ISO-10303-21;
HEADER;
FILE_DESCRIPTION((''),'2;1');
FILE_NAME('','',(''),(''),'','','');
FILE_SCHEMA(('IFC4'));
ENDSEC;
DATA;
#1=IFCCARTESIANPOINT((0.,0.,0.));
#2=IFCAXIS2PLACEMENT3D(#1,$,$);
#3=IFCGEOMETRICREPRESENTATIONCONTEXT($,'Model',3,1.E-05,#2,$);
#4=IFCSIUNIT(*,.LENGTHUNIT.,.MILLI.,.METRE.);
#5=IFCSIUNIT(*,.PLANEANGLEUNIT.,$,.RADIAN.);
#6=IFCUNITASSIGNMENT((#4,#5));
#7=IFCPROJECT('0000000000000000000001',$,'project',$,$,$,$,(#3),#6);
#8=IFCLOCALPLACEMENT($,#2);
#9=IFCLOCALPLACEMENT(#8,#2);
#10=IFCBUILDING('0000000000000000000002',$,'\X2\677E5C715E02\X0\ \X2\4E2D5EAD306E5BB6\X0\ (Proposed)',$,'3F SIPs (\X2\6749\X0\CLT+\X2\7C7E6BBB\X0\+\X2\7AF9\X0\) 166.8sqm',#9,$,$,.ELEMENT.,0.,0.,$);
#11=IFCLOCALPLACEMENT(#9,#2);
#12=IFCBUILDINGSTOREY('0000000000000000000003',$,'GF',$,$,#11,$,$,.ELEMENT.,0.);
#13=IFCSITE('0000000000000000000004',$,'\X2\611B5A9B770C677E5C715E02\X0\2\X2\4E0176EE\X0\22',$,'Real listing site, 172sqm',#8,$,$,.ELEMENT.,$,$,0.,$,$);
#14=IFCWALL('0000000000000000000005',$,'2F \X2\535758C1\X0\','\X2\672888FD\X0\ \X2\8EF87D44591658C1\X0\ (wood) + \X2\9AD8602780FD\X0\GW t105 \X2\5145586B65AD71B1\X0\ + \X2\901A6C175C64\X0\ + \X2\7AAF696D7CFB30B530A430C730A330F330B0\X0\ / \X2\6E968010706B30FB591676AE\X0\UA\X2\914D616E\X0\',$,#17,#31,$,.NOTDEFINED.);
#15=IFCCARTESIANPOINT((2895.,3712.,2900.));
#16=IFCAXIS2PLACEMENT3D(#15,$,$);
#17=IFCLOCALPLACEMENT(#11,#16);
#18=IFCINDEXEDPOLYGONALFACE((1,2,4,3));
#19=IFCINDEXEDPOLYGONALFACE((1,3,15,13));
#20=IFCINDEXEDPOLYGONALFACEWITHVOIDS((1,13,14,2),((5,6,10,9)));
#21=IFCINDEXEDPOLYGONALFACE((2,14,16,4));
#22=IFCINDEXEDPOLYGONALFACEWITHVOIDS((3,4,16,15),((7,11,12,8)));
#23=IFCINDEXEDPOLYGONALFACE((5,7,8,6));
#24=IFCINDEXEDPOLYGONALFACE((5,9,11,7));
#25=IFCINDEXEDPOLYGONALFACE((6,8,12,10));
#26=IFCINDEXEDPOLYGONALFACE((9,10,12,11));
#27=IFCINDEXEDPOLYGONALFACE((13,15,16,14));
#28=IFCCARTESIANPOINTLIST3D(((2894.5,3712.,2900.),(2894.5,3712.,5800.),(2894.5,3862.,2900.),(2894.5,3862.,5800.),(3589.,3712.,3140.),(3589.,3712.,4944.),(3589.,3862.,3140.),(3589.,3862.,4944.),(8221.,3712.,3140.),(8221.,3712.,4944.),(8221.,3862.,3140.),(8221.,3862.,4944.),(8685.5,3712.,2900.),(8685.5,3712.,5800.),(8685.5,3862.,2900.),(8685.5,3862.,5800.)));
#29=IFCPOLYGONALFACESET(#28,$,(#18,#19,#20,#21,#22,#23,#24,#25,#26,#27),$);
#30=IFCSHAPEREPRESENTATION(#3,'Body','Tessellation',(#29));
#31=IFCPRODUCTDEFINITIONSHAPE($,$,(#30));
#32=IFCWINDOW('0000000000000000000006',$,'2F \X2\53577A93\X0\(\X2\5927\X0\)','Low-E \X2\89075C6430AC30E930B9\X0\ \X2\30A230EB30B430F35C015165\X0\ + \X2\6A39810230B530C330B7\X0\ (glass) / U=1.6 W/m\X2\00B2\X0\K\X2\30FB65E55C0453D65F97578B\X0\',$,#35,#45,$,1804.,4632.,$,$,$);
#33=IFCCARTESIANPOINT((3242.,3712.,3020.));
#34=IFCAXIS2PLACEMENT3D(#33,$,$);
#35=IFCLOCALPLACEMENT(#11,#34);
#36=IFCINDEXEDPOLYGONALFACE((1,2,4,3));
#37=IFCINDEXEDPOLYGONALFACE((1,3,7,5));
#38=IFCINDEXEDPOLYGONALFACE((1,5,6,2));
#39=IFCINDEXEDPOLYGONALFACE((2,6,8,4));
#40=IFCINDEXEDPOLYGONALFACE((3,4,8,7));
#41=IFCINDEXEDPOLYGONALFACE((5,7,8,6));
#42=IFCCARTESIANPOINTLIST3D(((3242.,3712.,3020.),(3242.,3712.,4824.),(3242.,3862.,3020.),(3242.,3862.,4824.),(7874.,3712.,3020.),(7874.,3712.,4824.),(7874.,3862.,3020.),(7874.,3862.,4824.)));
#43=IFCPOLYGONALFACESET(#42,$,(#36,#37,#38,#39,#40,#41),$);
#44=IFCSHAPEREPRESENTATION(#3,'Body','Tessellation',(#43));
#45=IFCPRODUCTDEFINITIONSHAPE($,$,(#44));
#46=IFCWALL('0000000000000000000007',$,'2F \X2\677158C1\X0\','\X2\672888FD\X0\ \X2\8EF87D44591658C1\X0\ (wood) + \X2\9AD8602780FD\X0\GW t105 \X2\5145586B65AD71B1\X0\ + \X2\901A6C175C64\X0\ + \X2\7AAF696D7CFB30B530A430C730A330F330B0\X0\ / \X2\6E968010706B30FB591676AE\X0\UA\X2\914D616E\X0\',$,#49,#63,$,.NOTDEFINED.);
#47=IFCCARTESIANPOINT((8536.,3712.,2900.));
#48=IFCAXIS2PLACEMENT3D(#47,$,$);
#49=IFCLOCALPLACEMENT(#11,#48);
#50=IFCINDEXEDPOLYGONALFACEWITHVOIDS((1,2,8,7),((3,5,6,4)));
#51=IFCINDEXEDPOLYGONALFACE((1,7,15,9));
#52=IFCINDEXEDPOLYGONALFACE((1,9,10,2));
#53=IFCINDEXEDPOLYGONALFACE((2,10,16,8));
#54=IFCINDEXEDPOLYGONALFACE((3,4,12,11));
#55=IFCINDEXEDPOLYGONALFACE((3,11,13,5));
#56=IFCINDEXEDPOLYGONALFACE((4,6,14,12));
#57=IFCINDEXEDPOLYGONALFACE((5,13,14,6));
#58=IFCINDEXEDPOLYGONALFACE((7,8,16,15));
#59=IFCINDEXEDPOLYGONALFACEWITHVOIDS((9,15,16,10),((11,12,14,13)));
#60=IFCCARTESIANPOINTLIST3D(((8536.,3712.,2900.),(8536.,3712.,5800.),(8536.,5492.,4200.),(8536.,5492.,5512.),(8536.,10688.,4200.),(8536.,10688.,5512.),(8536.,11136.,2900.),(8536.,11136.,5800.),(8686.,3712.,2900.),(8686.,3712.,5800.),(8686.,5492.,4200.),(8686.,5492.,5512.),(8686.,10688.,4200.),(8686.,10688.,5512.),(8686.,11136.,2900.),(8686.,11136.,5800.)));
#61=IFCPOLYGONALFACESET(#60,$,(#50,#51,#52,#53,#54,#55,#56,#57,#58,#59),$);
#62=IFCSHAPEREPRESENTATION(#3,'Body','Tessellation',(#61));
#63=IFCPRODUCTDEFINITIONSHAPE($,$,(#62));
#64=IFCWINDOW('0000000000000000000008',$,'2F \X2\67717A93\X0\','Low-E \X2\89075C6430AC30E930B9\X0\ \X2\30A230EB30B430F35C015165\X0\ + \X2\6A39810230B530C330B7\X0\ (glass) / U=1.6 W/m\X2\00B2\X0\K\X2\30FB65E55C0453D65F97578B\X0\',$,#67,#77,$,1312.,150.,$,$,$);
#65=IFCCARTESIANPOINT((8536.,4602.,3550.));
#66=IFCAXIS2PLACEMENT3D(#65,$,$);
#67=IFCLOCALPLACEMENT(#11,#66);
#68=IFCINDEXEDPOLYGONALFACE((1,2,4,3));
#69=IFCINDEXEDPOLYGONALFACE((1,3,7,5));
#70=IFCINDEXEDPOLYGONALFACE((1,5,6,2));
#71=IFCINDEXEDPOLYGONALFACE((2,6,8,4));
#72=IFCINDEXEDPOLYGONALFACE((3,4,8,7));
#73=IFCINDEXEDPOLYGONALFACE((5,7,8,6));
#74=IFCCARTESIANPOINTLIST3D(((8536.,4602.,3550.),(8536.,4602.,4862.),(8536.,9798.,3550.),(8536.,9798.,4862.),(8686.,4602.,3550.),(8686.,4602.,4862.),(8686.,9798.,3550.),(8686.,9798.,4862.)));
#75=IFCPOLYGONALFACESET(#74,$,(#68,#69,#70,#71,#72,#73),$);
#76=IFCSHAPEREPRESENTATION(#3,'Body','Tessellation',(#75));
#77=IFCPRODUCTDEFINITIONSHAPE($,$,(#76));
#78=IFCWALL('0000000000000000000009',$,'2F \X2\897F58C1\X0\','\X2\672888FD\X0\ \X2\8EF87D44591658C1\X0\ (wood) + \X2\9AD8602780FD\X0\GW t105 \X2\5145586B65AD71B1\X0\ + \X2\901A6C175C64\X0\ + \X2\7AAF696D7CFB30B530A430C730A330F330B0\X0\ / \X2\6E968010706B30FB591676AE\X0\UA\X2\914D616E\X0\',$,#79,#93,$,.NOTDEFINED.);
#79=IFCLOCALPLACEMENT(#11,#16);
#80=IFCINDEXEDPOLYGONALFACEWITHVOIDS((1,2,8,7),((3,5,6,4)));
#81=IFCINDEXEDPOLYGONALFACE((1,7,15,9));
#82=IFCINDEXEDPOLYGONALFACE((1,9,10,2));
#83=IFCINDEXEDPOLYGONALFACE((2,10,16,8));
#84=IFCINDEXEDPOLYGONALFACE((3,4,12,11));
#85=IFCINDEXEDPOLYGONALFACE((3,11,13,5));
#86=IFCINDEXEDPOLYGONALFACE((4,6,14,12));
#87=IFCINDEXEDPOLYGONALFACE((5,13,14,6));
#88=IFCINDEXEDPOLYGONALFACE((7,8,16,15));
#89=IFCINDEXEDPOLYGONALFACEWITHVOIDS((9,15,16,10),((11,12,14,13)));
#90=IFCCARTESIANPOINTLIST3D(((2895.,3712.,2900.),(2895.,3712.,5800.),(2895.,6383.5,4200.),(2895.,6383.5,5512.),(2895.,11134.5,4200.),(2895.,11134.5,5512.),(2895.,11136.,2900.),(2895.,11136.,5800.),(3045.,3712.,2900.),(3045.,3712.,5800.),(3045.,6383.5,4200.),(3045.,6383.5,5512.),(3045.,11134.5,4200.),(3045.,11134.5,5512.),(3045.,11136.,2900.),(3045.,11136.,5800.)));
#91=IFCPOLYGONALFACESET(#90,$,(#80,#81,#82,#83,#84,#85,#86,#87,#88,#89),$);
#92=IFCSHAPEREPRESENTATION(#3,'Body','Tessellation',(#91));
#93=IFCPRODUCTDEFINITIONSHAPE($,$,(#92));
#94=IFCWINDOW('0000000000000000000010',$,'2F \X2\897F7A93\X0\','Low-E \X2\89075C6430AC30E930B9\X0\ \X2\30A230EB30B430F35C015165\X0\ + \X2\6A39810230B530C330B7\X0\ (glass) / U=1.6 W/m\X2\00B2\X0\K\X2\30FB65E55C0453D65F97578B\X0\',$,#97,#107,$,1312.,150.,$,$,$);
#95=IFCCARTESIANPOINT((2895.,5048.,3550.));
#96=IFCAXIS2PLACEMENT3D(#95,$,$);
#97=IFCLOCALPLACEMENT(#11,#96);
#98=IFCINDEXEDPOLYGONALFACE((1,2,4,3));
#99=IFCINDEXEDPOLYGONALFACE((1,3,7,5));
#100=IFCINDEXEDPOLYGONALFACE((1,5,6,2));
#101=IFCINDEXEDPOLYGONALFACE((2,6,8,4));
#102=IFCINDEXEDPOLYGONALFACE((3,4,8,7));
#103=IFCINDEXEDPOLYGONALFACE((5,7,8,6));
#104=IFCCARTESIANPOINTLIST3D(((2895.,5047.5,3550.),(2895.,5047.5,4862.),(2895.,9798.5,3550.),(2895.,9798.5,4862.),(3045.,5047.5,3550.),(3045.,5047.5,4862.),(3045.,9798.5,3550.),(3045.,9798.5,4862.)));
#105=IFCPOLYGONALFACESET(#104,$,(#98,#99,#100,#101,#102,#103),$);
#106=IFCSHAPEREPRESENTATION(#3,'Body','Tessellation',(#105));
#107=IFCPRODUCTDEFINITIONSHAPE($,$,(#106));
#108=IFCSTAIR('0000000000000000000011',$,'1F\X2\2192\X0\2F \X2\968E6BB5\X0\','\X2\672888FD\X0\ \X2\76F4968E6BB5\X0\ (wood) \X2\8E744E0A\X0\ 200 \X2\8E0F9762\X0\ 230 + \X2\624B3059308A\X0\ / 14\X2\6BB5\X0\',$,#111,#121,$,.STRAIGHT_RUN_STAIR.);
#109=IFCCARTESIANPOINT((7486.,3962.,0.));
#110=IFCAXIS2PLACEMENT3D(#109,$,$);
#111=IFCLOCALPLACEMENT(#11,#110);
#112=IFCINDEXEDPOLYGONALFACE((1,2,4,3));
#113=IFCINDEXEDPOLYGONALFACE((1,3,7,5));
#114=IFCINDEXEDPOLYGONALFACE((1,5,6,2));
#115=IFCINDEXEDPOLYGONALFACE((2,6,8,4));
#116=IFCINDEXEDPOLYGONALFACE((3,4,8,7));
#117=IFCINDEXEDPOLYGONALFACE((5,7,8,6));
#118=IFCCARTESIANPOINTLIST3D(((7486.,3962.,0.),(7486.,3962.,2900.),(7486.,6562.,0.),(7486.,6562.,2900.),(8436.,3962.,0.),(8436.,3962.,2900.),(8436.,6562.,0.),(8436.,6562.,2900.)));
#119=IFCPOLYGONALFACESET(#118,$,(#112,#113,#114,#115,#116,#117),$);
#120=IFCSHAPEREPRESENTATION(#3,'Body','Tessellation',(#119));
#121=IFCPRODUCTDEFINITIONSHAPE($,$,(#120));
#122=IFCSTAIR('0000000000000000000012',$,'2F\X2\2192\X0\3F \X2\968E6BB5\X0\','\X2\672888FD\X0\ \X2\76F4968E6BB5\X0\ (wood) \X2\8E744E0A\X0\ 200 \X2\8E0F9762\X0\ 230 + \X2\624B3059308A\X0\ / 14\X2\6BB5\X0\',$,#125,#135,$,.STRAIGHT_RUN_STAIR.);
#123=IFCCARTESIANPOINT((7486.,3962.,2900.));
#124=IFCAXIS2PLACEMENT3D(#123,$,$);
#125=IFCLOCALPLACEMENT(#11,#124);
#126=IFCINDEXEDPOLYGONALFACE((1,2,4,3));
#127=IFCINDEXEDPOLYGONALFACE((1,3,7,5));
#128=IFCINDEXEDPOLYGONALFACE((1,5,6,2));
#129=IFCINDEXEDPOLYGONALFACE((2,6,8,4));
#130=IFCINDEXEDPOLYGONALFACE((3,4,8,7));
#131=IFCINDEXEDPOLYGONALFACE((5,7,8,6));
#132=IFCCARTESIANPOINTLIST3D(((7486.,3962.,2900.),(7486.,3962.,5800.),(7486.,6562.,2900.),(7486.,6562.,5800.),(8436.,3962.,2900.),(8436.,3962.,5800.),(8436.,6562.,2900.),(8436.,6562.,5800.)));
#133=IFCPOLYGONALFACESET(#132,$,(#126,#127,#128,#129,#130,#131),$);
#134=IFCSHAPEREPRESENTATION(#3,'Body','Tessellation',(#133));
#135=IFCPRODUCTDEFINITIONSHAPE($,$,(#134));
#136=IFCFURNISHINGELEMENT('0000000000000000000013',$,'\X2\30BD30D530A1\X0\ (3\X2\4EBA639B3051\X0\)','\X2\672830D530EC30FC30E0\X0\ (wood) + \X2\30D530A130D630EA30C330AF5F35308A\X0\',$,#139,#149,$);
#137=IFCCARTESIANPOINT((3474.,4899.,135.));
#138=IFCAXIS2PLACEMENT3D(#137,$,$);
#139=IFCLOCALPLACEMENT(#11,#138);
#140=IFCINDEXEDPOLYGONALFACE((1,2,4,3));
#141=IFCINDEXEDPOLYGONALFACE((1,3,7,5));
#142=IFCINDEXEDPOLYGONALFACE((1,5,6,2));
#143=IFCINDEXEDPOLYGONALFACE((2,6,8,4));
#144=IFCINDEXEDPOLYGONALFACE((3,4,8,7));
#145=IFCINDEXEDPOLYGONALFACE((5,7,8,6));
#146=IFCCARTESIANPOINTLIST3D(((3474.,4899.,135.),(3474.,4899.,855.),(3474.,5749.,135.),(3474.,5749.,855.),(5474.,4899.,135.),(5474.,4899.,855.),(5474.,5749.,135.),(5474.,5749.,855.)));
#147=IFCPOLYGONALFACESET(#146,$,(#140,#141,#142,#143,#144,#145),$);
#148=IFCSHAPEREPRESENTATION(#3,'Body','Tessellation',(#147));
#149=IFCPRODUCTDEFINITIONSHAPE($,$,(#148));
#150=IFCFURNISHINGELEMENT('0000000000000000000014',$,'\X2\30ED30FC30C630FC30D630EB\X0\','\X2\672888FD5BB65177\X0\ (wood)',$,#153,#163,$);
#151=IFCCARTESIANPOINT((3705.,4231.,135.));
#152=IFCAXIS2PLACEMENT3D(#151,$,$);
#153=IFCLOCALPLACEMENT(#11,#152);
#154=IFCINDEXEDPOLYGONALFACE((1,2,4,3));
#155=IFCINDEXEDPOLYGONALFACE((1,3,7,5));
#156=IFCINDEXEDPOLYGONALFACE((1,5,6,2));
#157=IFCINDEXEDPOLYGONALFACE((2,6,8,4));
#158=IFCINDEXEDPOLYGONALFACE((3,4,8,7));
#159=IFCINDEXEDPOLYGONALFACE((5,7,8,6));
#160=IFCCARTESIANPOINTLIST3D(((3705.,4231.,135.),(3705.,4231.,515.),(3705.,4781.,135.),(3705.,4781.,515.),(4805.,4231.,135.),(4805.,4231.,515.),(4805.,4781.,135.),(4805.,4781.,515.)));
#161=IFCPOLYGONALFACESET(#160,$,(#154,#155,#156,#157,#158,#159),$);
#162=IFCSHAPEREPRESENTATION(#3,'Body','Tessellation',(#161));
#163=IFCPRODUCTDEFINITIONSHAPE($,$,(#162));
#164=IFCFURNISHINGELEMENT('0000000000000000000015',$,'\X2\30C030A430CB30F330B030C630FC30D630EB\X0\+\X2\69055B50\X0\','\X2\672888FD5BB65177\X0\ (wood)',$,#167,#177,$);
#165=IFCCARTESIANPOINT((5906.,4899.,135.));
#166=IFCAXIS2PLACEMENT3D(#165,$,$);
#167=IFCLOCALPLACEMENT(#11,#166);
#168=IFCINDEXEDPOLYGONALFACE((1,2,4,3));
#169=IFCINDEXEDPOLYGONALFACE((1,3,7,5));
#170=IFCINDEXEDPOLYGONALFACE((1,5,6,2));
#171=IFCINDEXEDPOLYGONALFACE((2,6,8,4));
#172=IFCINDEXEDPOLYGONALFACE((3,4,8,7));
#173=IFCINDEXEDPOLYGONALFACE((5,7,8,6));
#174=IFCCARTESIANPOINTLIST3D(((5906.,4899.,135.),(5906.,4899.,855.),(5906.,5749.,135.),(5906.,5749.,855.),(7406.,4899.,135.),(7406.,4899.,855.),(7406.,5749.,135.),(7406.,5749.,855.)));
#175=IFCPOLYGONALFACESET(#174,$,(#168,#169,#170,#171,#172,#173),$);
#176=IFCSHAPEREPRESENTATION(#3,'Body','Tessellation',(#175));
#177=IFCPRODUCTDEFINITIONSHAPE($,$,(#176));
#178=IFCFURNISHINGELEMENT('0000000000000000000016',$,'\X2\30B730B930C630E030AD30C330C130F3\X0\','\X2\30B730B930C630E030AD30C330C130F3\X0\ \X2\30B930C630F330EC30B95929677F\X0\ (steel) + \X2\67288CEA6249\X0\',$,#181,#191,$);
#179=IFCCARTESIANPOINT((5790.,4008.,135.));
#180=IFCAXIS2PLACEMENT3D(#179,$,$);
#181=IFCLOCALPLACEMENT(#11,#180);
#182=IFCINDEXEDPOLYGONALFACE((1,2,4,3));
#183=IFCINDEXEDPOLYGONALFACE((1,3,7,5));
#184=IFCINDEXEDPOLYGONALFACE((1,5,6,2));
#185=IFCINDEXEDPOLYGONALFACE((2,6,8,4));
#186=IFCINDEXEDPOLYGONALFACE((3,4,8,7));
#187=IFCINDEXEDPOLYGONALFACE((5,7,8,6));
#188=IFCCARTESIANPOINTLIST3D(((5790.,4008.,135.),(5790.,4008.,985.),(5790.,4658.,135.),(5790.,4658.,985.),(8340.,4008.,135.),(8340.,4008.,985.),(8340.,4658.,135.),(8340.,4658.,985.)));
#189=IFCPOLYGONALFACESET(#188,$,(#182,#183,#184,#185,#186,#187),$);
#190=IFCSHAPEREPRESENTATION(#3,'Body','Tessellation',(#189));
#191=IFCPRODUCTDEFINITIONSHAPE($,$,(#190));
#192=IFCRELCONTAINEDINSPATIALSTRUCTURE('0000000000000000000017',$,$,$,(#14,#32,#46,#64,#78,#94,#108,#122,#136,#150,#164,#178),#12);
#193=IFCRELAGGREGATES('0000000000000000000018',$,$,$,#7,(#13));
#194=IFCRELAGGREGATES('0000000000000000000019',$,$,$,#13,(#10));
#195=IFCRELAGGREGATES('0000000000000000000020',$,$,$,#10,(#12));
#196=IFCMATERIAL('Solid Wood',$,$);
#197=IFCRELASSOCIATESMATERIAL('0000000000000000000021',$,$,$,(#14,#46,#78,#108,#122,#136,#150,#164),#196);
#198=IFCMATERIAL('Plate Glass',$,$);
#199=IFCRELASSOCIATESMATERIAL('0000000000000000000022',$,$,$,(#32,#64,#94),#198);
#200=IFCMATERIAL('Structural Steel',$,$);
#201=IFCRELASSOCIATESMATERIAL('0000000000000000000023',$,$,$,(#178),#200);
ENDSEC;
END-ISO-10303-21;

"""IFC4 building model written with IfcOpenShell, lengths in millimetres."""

from ifc_helpers import new_model, si_unit, frame, frame_2d, origin, place, context, project, spatial, rectangle, extrude, material, element, fill, save


model = new_model("IFC4")

# Units and contexts
model_context = context("Model", 3, precision=1e-05, world=origin())
ifc_project = project(units=[si_unit("LENGTHUNIT", "METRE", prefix="MILLI"), si_unit("PLANEANGLEUNIT", "RADIAN")], contexts=[model_context])

# Site, building, storey
site_placement = place(None, origin())
site = spatial("IfcSite", under=ifc_project, at=site_placement, Name="愛媛県松山市2丁目22", ObjectType="Real listing site, 172sqm", CompositionType="ELEMENT", RefElevation=0.0)
building_placement = place(site_placement, origin())
building = spatial("IfcBuilding", under=site, at=building_placement, Name="松山市 中庭の家 (Proposed)", ObjectType="3F SIPs (杉CLT+籾殻+竹) 166.8sqm", CompositionType="ELEMENT", ElevationOfRefHeight=0.0, ElevationOfTerrain=0.0)
storey_placement = place(building_placement, origin())
storey = spatial("IfcBuildingStorey", under=building, at=storey_placement, Name="GF", CompositionType="ELEMENT", Elevation=0.0)

# Shared definitions
ifc_material_1 = material(Name="Solid Wood")

# Shared definitions
ifc_material_2 = material(Name="Plate Glass")

# Walls, openings, windows
wall_1_placement = place(storey_placement, frame((2895.0, 3712.0, 2900.0)))
wall_1 = element("IfcWall", 1, at=wall_1_placement, inside=storey, material=ifc_material_1, Name="2F 南壁", Description="木製 軸組外壁 (wood) + 高性能GW t105 充填断熱 + 通気層 + 窯業系サイディング / 準耐火・外皮UA配慮", PredefinedType="NOTDEFINED", context=model_context, shape_type="SweptSolid", body=[
    extrude(rectangle(XDim=5791.0, YDim=150.0, at=frame_2d((2895.0, 75.0))), frame((2895.0, 3712.0, 2900.0)), (0.0, 0.0, 1.0), 2900.0),
])
opening_1_placement = place(storey_placement, frame((3242.0, 3712.0, 3020.0)))
opening_1 = element("IfcOpeningElement", 2, at=opening_1_placement, cuts=wall_1, PredefinedType="NOTDEFINED", context=model_context, shape_type="SweptSolid", body=[
    extrude(rectangle(XDim=4632.0, YDim=150.0, at=frame_2d((2316.0, 75.0))), frame((3242.0, 3712.0, 3020.0)), (0.0, 0.0, 1.0), 1804.0),
])
window_1_placement = place(storey_placement, frame((3242.0, 3712.0, 3020.0)))
window_1 = element("IfcWindow", 3, at=window_1_placement, inside=storey, material=ifc_material_2, Name="2F 南窓(大)", Description="Low-E 複層ガラス アルゴン封入 + 樹脂サッシ (glass) / U=1.6 W/m²K・日射取得型", OverallHeight=1804.0, OverallWidth=4632.0, context=model_context, shape_type="SweptSolid", body=[
    extrude(rectangle(XDim=4632.0, YDim=150.0, at=frame_2d((2316.0, 75.0))), frame((3242.0, 3712.0, 3020.0)), (0.0, 0.0, 1.0), 1804.0),
])
fill(opening_1, window_1)
wall_2_placement = place(storey_placement, frame((8536.0, 3712.0, 2900.0)))
wall_2 = element("IfcWall", 4, at=wall_2_placement, inside=storey, material=ifc_material_1, Name="2F 東壁", Description="木製 軸組外壁 (wood) + 高性能GW t105 充填断熱 + 通気層 + 窯業系サイディング / 準耐火・外皮UA配慮", PredefinedType="NOTDEFINED", context=model_context, shape_type="SweptSolid", body=[
    extrude(rectangle(XDim=150.0, YDim=7424.0, at=frame_2d((75.0, 3712.0))), frame((8536.0, 3712.0, 2900.0)), (0.0, 0.0, 1.0), 2900.0),
])
opening_2_placement = place(storey_placement, frame((8536.0, 4602.0, 3550.0)))
opening_2 = element("IfcOpeningElement", 5, at=opening_2_placement, cuts=wall_2, PredefinedType="NOTDEFINED", context=model_context, shape_type="SweptSolid", body=[
    extrude(rectangle(XDim=150.0, YDim=5196.0, at=frame_2d((75.0, 2598.0))), frame((8536.0, 4602.0, 3550.0)), (0.0, 0.0, 1.0), 1312.0),
])
window_2_placement = place(storey_placement, frame((8536.0, 4602.0, 3550.0)))
window_2 = element("IfcWindow", 6, at=window_2_placement, inside=storey, material=ifc_material_2, Name="2F 東窓", Description="Low-E 複層ガラス アルゴン封入 + 樹脂サッシ (glass) / U=1.6 W/m²K・日射取得型", OverallHeight=1312.0, OverallWidth=150.0, context=model_context, shape_type="SweptSolid", body=[
    extrude(rectangle(XDim=150.0, YDim=5196.0, at=frame_2d((75.0, 2598.0))), frame((8536.0, 4602.0, 3550.0)), (0.0, 0.0, 1.0), 1312.0),
])
fill(opening_2, window_2)
wall_3_placement = place(storey_placement, frame((2895.0, 3712.0, 2900.0)))
wall_3 = element("IfcWall", 7, at=wall_3_placement, inside=storey, material=ifc_material_1, Name="2F 西壁", Description="木製 軸組外壁 (wood) + 高性能GW t105 充填断熱 + 通気層 + 窯業系サイディング / 準耐火・外皮UA配慮", PredefinedType="NOTDEFINED", context=model_context, shape_type="SweptSolid", body=[
    extrude(rectangle(XDim=150.0, YDim=7424.0, at=frame_2d((75.0, 3712.0))), frame((2895.0, 3712.0, 2900.0)), (0.0, 0.0, 1.0), 2900.0),
])
opening_3_placement = place(storey_placement, frame((2895.0, 5048.0, 3550.0)))
opening_3 = element("IfcOpeningElement", 8, at=opening_3_placement, cuts=wall_3, PredefinedType="NOTDEFINED", context=model_context, shape_type="SweptSolid", body=[
    extrude(rectangle(XDim=150.0, YDim=4751.0, at=frame_2d((75.0, 2375.0))), frame((2895.0, 5048.0, 3550.0)), (0.0, 0.0, 1.0), 1312.0),
])
window_3_placement = place(storey_placement, frame((2895.0, 5048.0, 3550.0)))
window_3 = element("IfcWindow", 9, at=window_3_placement, inside=storey, material=ifc_material_2, Name="2F 西窓", Description="Low-E 複層ガラス アルゴン封入 + 樹脂サッシ (glass) / U=1.6 W/m²K・日射取得型", OverallHeight=1312.0, OverallWidth=150.0, context=model_context, shape_type="SweptSolid", body=[
    extrude(rectangle(XDim=150.0, YDim=4751.0, at=frame_2d((75.0, 2375.0))), frame((2895.0, 5048.0, 3550.0)), (0.0, 0.0, 1.0), 1312.0),
])
fill(opening_3, window_3)

# Stairs
stair_1_placement = place(storey_placement, frame((7486.0, 3962.0, 0.0)))
element("IfcStair", 10, at=stair_1_placement, inside=storey, material=ifc_material_1, Name="1F→2F 階段", Description="木製 直階段 (wood) 蹴上 200 踏面 230 + 手すり / 14段", PredefinedType="STRAIGHT_RUN_STAIR", context=model_context, shape_type="SweptSolid", body=[
    extrude(rectangle(XDim=950.0, YDim=2600.0, at=frame_2d((475.0, 1300.0))), frame((7486.0, 3962.0, 0.0)), (0.0, 0.0, 1.0), 2900.0),
])
stair_2_placement = place(storey_placement, frame((7486.0, 3962.0, 2900.0)))
element("IfcStair", 11, at=stair_2_placement, inside=storey, material=ifc_material_1, Name="2F→3F 階段", Description="木製 直階段 (wood) 蹴上 200 踏面 230 + 手すり / 14段", PredefinedType="STRAIGHT_RUN_STAIR", context=model_context, shape_type="SweptSolid", body=[
    extrude(rectangle(XDim=950.0, YDim=2600.0, at=frame_2d((475.0, 1300.0))), frame((7486.0, 3962.0, 2900.0)), (0.0, 0.0, 1.0), 2900.0),
])

# Furnishing elements
furnishing_1_placement = place(storey_placement, frame((3474.0, 4899.0, 135.0)))
element("IfcFurnishingElement", 12, at=furnishing_1_placement, inside=storey, material=ifc_material_1, Name="ソファ (3人掛け)", Description="木フレーム (wood) + ファブリック張り", context=model_context, shape_type="SweptSolid", body=[
    extrude(rectangle(XDim=2000.0, YDim=850.0, at=frame_2d((1000.0, 425.0))), frame((3474.0, 4899.0, 135.0)), (0.0, 0.0, 1.0), 720.0),
])
furnishing_2_placement = place(storey_placement, frame((3705.0, 4231.0, 135.0)))
element("IfcFurnishingElement", 13, at=furnishing_2_placement, inside=storey, material=ifc_material_1, Name="ローテーブル", Description="木製家具 (wood)", context=model_context, shape_type="SweptSolid", body=[
    extrude(rectangle(XDim=1100.0, YDim=550.0, at=frame_2d((550.0, 275.0))), frame((3705.0, 4231.0, 135.0)), (0.0, 0.0, 1.0), 380.0),
])
furnishing_3_placement = place(storey_placement, frame((5906.0, 4899.0, 135.0)))
element("IfcFurnishingElement", 14, at=furnishing_3_placement, inside=storey, material=ifc_material_1, Name="ダイニングテーブル+椅子", Description="木製家具 (wood)", context=model_context, shape_type="SweptSolid", body=[
    extrude(rectangle(XDim=1500.0, YDim=850.0, at=frame_2d((750.0, 425.0))), frame((5906.0, 4899.0, 135.0)), (0.0, 0.0, 1.0), 720.0),
])
ifc_material_3 = material(Name="Structural Steel")
furnishing_4_placement = place(storey_placement, frame((5790.0, 4008.0, 135.0)))
element("IfcFurnishingElement", 15, at=furnishing_4_placement, inside=storey, material=ifc_material_3, Name="システムキッチン", Description="システムキッチン ステンレス天板 (steel) + 木質扉", context=model_context, shape_type="SweptSolid", body=[
    extrude(rectangle(XDim=2550.0, YDim=650.0, at=frame_2d((1275.0, 325.0))), frame((5790.0, 4008.0, 135.0)), (0.0, 0.0, 1.0), 850.0),
])

save(model, "model.ifc")
